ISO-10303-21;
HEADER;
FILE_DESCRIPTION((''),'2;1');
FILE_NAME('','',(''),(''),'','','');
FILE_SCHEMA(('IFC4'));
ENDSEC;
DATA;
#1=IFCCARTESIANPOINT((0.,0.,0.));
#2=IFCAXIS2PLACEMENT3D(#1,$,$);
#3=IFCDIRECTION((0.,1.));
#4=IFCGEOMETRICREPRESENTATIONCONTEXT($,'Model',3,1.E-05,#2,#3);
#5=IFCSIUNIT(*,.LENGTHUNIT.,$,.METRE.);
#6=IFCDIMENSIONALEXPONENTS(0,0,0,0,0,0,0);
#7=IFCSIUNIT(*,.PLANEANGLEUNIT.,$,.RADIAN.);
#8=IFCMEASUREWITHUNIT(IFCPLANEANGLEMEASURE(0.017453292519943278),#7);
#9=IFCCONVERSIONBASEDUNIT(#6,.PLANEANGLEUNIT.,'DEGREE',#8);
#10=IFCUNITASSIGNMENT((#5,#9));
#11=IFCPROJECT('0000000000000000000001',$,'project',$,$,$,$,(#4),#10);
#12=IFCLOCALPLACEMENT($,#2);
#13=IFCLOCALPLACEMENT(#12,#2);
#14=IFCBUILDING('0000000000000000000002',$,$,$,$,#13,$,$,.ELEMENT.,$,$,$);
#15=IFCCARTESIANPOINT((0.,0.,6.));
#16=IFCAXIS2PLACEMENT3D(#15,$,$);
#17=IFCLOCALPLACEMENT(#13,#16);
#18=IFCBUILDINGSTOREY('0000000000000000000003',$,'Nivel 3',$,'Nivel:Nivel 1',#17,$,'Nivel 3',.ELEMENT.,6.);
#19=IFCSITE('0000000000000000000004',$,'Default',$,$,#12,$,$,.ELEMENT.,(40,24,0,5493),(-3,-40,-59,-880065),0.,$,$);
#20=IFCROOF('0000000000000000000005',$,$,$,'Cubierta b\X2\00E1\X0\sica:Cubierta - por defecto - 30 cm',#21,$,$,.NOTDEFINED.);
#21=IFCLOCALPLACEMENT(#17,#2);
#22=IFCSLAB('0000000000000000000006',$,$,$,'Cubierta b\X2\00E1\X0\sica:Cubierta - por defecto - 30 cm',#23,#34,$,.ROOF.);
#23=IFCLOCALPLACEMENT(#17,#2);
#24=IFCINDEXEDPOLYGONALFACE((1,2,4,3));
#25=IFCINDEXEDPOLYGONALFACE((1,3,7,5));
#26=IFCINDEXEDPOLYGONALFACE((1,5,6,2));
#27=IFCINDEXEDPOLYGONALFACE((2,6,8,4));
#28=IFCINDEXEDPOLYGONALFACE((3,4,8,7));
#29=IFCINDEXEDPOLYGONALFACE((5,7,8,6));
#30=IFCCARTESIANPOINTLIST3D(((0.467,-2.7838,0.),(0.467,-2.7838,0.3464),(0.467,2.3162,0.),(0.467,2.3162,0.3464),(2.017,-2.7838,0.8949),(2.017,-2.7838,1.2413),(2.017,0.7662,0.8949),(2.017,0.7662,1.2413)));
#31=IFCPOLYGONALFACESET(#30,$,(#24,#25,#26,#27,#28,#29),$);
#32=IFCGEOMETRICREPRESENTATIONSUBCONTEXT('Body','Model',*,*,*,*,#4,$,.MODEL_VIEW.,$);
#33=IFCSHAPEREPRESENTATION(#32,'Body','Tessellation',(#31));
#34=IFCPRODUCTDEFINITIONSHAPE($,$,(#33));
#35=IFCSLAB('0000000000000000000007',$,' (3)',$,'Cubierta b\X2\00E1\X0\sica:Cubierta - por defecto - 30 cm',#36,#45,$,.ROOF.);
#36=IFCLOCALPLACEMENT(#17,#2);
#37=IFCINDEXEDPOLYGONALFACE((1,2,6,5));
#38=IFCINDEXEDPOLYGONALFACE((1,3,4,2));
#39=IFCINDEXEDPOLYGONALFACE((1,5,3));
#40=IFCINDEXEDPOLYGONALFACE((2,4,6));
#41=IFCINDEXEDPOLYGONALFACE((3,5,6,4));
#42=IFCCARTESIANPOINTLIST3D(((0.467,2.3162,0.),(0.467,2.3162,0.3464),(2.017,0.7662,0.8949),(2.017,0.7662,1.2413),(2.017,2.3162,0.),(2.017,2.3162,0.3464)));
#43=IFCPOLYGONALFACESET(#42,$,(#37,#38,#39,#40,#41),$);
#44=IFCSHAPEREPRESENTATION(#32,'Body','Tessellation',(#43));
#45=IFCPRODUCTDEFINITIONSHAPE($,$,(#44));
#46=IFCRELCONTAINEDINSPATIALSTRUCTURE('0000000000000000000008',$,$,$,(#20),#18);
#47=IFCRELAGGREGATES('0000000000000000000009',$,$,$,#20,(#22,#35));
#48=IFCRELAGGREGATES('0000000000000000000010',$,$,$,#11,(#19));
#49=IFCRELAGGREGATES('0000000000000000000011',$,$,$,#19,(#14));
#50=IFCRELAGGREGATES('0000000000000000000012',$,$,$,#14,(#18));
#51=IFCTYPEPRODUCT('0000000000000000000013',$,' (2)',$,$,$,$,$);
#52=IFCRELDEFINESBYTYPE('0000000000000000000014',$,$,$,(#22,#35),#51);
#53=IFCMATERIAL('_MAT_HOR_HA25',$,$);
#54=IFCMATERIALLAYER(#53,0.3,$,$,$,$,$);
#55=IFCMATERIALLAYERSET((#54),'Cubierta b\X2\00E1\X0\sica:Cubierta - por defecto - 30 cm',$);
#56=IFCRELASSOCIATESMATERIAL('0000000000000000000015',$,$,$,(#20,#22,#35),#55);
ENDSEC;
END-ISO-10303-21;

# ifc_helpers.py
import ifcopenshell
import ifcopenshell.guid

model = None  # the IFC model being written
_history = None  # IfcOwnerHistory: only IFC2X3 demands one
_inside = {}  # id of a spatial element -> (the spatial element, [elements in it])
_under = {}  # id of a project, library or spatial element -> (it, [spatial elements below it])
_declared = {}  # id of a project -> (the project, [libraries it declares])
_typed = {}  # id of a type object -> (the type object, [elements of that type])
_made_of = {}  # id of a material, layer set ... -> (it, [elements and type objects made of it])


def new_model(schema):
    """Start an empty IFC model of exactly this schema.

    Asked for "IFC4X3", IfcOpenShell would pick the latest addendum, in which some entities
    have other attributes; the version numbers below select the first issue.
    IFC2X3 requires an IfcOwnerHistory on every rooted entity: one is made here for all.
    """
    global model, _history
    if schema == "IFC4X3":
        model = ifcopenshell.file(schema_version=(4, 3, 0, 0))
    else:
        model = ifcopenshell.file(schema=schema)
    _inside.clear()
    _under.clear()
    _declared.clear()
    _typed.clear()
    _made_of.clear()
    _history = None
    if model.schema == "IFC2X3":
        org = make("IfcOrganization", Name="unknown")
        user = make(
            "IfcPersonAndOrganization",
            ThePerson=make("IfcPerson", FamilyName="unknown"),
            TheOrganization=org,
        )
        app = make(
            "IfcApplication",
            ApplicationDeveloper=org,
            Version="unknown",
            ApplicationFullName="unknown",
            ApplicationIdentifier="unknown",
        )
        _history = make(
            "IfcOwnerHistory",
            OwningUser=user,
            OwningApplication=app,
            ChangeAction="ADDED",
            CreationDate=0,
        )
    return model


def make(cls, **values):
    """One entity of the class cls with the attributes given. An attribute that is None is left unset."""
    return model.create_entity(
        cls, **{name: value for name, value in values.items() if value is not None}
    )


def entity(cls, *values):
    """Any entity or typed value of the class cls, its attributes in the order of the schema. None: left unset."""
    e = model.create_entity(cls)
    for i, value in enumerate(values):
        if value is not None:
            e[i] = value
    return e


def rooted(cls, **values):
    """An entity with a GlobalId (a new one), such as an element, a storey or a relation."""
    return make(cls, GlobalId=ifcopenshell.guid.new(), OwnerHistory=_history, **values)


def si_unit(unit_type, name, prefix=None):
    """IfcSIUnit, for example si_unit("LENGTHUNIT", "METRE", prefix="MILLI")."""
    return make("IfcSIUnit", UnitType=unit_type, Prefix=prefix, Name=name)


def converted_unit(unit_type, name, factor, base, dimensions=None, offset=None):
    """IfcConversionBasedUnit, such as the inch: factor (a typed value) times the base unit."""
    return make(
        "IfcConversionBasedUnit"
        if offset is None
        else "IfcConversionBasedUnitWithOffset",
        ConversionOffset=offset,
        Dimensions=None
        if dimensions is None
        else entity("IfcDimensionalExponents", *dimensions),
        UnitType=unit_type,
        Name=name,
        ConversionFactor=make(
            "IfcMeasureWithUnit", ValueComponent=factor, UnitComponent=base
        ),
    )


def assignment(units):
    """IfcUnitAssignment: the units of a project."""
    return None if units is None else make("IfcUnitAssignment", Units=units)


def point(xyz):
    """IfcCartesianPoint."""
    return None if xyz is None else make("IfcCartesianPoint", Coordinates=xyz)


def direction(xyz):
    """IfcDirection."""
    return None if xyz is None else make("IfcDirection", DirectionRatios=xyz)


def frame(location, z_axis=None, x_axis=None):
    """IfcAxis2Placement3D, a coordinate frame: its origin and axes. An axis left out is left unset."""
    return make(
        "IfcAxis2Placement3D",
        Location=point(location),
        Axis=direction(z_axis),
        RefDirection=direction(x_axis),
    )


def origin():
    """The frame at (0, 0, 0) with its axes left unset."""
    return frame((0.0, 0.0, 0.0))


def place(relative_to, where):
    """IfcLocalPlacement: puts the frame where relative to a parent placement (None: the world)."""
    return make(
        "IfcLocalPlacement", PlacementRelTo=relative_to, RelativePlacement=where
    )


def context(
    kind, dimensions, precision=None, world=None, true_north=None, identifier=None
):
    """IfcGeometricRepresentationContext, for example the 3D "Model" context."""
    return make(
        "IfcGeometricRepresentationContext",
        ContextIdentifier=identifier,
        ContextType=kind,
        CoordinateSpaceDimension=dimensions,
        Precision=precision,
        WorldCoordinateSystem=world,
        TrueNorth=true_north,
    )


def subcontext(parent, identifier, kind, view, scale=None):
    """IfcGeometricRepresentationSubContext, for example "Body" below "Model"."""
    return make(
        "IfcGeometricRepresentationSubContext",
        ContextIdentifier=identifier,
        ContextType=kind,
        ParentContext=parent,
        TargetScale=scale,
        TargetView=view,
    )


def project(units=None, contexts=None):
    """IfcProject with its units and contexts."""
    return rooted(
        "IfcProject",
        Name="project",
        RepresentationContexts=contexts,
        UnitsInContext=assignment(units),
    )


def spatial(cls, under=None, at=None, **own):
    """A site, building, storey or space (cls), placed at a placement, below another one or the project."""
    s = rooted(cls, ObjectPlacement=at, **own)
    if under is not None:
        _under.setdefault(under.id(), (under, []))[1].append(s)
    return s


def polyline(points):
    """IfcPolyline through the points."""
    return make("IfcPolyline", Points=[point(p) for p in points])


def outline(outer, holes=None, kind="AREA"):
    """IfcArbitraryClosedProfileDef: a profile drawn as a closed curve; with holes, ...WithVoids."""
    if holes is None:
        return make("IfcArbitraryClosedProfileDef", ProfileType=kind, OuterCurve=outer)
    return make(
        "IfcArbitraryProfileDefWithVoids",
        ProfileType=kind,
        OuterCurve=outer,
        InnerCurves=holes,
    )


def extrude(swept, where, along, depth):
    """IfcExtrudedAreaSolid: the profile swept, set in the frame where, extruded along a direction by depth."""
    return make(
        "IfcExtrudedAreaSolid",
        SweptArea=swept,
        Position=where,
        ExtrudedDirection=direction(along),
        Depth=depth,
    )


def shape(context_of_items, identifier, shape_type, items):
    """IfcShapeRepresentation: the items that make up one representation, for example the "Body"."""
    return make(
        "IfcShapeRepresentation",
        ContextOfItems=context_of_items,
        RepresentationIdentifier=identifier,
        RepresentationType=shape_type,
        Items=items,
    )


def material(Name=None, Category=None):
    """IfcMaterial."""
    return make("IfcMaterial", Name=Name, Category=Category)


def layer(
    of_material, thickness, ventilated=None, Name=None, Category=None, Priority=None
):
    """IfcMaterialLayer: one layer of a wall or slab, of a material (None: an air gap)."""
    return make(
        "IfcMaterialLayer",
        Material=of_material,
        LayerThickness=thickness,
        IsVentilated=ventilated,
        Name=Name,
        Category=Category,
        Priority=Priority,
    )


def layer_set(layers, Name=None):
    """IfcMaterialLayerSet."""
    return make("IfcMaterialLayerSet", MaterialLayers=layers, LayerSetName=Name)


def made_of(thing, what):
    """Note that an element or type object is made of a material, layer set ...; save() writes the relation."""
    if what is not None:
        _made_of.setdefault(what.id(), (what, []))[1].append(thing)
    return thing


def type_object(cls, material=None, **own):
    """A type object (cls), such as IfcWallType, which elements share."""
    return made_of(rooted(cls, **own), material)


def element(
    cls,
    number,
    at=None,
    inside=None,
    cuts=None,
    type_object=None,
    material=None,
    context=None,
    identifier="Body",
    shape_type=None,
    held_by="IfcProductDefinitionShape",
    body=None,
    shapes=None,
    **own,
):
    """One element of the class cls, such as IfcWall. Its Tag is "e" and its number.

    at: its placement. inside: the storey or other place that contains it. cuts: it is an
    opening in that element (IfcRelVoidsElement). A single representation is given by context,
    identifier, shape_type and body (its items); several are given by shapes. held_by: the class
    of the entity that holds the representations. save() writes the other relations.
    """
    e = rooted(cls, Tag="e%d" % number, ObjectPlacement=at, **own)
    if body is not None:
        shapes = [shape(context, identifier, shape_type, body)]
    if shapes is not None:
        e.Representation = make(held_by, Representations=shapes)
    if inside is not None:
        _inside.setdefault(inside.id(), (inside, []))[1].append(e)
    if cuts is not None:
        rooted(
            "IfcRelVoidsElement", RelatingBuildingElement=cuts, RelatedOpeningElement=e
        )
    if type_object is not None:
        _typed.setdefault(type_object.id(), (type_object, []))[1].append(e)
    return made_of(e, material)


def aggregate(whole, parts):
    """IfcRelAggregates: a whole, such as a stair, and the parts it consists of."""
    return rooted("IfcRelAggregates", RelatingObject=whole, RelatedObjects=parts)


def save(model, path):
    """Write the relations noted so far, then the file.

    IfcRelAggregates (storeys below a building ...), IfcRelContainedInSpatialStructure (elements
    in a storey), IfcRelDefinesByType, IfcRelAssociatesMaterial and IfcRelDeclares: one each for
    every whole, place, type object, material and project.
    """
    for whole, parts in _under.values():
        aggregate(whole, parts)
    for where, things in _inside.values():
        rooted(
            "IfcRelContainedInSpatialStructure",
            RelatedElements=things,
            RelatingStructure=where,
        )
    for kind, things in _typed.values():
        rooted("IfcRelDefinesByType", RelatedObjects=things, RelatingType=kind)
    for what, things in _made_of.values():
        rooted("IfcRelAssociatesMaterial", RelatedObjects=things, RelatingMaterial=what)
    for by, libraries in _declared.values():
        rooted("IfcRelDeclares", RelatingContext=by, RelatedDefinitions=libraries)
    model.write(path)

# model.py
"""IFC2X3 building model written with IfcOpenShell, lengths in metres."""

from ifc_helpers import new_model, entity, si_unit, converted_unit, direction, frame, origin, place, context, subcontext, project, spatial, polyline, outline, extrude, material, layer, layer_set, type_object, element, aggregate, save


model = new_model("IFC2X3")

# Units and contexts
model_context = context("Model", 3, precision=1e-05, world=origin(), true_north=direction((0.0, 1.0)))
body_context = subcontext(model_context, "Body", "Model", "MODEL_VIEW")
ifc_project = project(units=[si_unit("LENGTHUNIT", "METRE"), converted_unit("PLANEANGLEUNIT", "DEGREE", entity("IfcPlaneAngleMeasure", 0.017453292519943278), si_unit("PLANEANGLEUNIT", "RADIAN"), dimensions=[0, 0, 0, 0, 0, 0, 0])], contexts=[model_context])

# Site, building, storey
site_placement = place(None, origin())
site = spatial("IfcSite", under=ifc_project, at=site_placement, Name="Default", CompositionType="ELEMENT", RefLatitude=(40, 24, 0, 5493), RefLongitude=(-3, -40, -59, -880065), RefElevation=0.0)
building_placement = place(site_placement, origin())
building = spatial("IfcBuilding", under=site, at=building_placement, CompositionType="ELEMENT")
storey_placement = place(building_placement, frame((0.0, 0.0, 6.0)))
storey = spatial("IfcBuildingStorey", under=building, at=storey_placement, Name="Nivel 3", ObjectType="Nivel:Nivel 1", LongName="Nivel 3", CompositionType="ELEMENT", Elevation=6.0)

# Roof, slabs
ifc_material = material(Name="_MAT_HOR_HA25")
ifc_layer = layer(ifc_material, 0.3)
ifc_layer_set = layer_set([ifc_layer], Name="Cubierta básica:Cubierta - por defecto - 30 cm")
roof_placement = place(storey_placement, frame((0.467, -2.7838, 0.0)))
roof = element("IfcRoof", 1, at=roof_placement, inside=storey, material=ifc_layer_set, ObjectType="Cubierta básica:Cubierta - por defecto - 30 cm", ShapeType="NOTDEFINED")
type_product = type_object("IfcTypeProduct", Name=" (2)")
slab_1_placement = place(roof_placement, origin())
slab_1 = element("IfcSlab", 2, at=slab_1_placement, type_object=type_product, material=ifc_layer_set, ObjectType="Cubierta básica:Cubierta - por defecto - 30 cm", PredefinedType="ROOF", context=body_context, shape_type="SweptSolid", body=[
    extrude(outline(polyline([(0.8949, 1.0), (-0.8949, 2.55), (-0.8949, -2.55), (0.8949, -2.55), (0.8949, 1.0)])), frame((0.775, 2.55, 0.4474), z_axis=(-0.5, 0.0, 0.866025), x_axis=(0.866025, 0.0, 0.5)), (0.5, 0.0, 0.866025), 0.3464),
])
slab_2_placement = place(roof_placement, origin())
slab_2 = element("IfcSlab", 3, at=slab_2_placement, type_object=type_product, material=ifc_layer_set, Name=" (3)", ObjectType="Cubierta básica:Cubierta - por defecto - 30 cm", PredefinedType="ROOF", context=body_context, shape_type="SweptSolid", body=[
    extrude(outline(polyline([(-0.775, 0.8949), (0.775, -0.8949), (0.775, 0.8949), (-0.775, 0.8949)])), frame((0.775, 4.325, 0.4474), z_axis=(0.0, 0.5, 0.866025), x_axis=(1.0, 0.0, 0.0)), (0.0, -0.5, 0.866025), 0.3464),
])
aggregate(roof, [slab_1, slab_2])

save(model, "model.ifc")
